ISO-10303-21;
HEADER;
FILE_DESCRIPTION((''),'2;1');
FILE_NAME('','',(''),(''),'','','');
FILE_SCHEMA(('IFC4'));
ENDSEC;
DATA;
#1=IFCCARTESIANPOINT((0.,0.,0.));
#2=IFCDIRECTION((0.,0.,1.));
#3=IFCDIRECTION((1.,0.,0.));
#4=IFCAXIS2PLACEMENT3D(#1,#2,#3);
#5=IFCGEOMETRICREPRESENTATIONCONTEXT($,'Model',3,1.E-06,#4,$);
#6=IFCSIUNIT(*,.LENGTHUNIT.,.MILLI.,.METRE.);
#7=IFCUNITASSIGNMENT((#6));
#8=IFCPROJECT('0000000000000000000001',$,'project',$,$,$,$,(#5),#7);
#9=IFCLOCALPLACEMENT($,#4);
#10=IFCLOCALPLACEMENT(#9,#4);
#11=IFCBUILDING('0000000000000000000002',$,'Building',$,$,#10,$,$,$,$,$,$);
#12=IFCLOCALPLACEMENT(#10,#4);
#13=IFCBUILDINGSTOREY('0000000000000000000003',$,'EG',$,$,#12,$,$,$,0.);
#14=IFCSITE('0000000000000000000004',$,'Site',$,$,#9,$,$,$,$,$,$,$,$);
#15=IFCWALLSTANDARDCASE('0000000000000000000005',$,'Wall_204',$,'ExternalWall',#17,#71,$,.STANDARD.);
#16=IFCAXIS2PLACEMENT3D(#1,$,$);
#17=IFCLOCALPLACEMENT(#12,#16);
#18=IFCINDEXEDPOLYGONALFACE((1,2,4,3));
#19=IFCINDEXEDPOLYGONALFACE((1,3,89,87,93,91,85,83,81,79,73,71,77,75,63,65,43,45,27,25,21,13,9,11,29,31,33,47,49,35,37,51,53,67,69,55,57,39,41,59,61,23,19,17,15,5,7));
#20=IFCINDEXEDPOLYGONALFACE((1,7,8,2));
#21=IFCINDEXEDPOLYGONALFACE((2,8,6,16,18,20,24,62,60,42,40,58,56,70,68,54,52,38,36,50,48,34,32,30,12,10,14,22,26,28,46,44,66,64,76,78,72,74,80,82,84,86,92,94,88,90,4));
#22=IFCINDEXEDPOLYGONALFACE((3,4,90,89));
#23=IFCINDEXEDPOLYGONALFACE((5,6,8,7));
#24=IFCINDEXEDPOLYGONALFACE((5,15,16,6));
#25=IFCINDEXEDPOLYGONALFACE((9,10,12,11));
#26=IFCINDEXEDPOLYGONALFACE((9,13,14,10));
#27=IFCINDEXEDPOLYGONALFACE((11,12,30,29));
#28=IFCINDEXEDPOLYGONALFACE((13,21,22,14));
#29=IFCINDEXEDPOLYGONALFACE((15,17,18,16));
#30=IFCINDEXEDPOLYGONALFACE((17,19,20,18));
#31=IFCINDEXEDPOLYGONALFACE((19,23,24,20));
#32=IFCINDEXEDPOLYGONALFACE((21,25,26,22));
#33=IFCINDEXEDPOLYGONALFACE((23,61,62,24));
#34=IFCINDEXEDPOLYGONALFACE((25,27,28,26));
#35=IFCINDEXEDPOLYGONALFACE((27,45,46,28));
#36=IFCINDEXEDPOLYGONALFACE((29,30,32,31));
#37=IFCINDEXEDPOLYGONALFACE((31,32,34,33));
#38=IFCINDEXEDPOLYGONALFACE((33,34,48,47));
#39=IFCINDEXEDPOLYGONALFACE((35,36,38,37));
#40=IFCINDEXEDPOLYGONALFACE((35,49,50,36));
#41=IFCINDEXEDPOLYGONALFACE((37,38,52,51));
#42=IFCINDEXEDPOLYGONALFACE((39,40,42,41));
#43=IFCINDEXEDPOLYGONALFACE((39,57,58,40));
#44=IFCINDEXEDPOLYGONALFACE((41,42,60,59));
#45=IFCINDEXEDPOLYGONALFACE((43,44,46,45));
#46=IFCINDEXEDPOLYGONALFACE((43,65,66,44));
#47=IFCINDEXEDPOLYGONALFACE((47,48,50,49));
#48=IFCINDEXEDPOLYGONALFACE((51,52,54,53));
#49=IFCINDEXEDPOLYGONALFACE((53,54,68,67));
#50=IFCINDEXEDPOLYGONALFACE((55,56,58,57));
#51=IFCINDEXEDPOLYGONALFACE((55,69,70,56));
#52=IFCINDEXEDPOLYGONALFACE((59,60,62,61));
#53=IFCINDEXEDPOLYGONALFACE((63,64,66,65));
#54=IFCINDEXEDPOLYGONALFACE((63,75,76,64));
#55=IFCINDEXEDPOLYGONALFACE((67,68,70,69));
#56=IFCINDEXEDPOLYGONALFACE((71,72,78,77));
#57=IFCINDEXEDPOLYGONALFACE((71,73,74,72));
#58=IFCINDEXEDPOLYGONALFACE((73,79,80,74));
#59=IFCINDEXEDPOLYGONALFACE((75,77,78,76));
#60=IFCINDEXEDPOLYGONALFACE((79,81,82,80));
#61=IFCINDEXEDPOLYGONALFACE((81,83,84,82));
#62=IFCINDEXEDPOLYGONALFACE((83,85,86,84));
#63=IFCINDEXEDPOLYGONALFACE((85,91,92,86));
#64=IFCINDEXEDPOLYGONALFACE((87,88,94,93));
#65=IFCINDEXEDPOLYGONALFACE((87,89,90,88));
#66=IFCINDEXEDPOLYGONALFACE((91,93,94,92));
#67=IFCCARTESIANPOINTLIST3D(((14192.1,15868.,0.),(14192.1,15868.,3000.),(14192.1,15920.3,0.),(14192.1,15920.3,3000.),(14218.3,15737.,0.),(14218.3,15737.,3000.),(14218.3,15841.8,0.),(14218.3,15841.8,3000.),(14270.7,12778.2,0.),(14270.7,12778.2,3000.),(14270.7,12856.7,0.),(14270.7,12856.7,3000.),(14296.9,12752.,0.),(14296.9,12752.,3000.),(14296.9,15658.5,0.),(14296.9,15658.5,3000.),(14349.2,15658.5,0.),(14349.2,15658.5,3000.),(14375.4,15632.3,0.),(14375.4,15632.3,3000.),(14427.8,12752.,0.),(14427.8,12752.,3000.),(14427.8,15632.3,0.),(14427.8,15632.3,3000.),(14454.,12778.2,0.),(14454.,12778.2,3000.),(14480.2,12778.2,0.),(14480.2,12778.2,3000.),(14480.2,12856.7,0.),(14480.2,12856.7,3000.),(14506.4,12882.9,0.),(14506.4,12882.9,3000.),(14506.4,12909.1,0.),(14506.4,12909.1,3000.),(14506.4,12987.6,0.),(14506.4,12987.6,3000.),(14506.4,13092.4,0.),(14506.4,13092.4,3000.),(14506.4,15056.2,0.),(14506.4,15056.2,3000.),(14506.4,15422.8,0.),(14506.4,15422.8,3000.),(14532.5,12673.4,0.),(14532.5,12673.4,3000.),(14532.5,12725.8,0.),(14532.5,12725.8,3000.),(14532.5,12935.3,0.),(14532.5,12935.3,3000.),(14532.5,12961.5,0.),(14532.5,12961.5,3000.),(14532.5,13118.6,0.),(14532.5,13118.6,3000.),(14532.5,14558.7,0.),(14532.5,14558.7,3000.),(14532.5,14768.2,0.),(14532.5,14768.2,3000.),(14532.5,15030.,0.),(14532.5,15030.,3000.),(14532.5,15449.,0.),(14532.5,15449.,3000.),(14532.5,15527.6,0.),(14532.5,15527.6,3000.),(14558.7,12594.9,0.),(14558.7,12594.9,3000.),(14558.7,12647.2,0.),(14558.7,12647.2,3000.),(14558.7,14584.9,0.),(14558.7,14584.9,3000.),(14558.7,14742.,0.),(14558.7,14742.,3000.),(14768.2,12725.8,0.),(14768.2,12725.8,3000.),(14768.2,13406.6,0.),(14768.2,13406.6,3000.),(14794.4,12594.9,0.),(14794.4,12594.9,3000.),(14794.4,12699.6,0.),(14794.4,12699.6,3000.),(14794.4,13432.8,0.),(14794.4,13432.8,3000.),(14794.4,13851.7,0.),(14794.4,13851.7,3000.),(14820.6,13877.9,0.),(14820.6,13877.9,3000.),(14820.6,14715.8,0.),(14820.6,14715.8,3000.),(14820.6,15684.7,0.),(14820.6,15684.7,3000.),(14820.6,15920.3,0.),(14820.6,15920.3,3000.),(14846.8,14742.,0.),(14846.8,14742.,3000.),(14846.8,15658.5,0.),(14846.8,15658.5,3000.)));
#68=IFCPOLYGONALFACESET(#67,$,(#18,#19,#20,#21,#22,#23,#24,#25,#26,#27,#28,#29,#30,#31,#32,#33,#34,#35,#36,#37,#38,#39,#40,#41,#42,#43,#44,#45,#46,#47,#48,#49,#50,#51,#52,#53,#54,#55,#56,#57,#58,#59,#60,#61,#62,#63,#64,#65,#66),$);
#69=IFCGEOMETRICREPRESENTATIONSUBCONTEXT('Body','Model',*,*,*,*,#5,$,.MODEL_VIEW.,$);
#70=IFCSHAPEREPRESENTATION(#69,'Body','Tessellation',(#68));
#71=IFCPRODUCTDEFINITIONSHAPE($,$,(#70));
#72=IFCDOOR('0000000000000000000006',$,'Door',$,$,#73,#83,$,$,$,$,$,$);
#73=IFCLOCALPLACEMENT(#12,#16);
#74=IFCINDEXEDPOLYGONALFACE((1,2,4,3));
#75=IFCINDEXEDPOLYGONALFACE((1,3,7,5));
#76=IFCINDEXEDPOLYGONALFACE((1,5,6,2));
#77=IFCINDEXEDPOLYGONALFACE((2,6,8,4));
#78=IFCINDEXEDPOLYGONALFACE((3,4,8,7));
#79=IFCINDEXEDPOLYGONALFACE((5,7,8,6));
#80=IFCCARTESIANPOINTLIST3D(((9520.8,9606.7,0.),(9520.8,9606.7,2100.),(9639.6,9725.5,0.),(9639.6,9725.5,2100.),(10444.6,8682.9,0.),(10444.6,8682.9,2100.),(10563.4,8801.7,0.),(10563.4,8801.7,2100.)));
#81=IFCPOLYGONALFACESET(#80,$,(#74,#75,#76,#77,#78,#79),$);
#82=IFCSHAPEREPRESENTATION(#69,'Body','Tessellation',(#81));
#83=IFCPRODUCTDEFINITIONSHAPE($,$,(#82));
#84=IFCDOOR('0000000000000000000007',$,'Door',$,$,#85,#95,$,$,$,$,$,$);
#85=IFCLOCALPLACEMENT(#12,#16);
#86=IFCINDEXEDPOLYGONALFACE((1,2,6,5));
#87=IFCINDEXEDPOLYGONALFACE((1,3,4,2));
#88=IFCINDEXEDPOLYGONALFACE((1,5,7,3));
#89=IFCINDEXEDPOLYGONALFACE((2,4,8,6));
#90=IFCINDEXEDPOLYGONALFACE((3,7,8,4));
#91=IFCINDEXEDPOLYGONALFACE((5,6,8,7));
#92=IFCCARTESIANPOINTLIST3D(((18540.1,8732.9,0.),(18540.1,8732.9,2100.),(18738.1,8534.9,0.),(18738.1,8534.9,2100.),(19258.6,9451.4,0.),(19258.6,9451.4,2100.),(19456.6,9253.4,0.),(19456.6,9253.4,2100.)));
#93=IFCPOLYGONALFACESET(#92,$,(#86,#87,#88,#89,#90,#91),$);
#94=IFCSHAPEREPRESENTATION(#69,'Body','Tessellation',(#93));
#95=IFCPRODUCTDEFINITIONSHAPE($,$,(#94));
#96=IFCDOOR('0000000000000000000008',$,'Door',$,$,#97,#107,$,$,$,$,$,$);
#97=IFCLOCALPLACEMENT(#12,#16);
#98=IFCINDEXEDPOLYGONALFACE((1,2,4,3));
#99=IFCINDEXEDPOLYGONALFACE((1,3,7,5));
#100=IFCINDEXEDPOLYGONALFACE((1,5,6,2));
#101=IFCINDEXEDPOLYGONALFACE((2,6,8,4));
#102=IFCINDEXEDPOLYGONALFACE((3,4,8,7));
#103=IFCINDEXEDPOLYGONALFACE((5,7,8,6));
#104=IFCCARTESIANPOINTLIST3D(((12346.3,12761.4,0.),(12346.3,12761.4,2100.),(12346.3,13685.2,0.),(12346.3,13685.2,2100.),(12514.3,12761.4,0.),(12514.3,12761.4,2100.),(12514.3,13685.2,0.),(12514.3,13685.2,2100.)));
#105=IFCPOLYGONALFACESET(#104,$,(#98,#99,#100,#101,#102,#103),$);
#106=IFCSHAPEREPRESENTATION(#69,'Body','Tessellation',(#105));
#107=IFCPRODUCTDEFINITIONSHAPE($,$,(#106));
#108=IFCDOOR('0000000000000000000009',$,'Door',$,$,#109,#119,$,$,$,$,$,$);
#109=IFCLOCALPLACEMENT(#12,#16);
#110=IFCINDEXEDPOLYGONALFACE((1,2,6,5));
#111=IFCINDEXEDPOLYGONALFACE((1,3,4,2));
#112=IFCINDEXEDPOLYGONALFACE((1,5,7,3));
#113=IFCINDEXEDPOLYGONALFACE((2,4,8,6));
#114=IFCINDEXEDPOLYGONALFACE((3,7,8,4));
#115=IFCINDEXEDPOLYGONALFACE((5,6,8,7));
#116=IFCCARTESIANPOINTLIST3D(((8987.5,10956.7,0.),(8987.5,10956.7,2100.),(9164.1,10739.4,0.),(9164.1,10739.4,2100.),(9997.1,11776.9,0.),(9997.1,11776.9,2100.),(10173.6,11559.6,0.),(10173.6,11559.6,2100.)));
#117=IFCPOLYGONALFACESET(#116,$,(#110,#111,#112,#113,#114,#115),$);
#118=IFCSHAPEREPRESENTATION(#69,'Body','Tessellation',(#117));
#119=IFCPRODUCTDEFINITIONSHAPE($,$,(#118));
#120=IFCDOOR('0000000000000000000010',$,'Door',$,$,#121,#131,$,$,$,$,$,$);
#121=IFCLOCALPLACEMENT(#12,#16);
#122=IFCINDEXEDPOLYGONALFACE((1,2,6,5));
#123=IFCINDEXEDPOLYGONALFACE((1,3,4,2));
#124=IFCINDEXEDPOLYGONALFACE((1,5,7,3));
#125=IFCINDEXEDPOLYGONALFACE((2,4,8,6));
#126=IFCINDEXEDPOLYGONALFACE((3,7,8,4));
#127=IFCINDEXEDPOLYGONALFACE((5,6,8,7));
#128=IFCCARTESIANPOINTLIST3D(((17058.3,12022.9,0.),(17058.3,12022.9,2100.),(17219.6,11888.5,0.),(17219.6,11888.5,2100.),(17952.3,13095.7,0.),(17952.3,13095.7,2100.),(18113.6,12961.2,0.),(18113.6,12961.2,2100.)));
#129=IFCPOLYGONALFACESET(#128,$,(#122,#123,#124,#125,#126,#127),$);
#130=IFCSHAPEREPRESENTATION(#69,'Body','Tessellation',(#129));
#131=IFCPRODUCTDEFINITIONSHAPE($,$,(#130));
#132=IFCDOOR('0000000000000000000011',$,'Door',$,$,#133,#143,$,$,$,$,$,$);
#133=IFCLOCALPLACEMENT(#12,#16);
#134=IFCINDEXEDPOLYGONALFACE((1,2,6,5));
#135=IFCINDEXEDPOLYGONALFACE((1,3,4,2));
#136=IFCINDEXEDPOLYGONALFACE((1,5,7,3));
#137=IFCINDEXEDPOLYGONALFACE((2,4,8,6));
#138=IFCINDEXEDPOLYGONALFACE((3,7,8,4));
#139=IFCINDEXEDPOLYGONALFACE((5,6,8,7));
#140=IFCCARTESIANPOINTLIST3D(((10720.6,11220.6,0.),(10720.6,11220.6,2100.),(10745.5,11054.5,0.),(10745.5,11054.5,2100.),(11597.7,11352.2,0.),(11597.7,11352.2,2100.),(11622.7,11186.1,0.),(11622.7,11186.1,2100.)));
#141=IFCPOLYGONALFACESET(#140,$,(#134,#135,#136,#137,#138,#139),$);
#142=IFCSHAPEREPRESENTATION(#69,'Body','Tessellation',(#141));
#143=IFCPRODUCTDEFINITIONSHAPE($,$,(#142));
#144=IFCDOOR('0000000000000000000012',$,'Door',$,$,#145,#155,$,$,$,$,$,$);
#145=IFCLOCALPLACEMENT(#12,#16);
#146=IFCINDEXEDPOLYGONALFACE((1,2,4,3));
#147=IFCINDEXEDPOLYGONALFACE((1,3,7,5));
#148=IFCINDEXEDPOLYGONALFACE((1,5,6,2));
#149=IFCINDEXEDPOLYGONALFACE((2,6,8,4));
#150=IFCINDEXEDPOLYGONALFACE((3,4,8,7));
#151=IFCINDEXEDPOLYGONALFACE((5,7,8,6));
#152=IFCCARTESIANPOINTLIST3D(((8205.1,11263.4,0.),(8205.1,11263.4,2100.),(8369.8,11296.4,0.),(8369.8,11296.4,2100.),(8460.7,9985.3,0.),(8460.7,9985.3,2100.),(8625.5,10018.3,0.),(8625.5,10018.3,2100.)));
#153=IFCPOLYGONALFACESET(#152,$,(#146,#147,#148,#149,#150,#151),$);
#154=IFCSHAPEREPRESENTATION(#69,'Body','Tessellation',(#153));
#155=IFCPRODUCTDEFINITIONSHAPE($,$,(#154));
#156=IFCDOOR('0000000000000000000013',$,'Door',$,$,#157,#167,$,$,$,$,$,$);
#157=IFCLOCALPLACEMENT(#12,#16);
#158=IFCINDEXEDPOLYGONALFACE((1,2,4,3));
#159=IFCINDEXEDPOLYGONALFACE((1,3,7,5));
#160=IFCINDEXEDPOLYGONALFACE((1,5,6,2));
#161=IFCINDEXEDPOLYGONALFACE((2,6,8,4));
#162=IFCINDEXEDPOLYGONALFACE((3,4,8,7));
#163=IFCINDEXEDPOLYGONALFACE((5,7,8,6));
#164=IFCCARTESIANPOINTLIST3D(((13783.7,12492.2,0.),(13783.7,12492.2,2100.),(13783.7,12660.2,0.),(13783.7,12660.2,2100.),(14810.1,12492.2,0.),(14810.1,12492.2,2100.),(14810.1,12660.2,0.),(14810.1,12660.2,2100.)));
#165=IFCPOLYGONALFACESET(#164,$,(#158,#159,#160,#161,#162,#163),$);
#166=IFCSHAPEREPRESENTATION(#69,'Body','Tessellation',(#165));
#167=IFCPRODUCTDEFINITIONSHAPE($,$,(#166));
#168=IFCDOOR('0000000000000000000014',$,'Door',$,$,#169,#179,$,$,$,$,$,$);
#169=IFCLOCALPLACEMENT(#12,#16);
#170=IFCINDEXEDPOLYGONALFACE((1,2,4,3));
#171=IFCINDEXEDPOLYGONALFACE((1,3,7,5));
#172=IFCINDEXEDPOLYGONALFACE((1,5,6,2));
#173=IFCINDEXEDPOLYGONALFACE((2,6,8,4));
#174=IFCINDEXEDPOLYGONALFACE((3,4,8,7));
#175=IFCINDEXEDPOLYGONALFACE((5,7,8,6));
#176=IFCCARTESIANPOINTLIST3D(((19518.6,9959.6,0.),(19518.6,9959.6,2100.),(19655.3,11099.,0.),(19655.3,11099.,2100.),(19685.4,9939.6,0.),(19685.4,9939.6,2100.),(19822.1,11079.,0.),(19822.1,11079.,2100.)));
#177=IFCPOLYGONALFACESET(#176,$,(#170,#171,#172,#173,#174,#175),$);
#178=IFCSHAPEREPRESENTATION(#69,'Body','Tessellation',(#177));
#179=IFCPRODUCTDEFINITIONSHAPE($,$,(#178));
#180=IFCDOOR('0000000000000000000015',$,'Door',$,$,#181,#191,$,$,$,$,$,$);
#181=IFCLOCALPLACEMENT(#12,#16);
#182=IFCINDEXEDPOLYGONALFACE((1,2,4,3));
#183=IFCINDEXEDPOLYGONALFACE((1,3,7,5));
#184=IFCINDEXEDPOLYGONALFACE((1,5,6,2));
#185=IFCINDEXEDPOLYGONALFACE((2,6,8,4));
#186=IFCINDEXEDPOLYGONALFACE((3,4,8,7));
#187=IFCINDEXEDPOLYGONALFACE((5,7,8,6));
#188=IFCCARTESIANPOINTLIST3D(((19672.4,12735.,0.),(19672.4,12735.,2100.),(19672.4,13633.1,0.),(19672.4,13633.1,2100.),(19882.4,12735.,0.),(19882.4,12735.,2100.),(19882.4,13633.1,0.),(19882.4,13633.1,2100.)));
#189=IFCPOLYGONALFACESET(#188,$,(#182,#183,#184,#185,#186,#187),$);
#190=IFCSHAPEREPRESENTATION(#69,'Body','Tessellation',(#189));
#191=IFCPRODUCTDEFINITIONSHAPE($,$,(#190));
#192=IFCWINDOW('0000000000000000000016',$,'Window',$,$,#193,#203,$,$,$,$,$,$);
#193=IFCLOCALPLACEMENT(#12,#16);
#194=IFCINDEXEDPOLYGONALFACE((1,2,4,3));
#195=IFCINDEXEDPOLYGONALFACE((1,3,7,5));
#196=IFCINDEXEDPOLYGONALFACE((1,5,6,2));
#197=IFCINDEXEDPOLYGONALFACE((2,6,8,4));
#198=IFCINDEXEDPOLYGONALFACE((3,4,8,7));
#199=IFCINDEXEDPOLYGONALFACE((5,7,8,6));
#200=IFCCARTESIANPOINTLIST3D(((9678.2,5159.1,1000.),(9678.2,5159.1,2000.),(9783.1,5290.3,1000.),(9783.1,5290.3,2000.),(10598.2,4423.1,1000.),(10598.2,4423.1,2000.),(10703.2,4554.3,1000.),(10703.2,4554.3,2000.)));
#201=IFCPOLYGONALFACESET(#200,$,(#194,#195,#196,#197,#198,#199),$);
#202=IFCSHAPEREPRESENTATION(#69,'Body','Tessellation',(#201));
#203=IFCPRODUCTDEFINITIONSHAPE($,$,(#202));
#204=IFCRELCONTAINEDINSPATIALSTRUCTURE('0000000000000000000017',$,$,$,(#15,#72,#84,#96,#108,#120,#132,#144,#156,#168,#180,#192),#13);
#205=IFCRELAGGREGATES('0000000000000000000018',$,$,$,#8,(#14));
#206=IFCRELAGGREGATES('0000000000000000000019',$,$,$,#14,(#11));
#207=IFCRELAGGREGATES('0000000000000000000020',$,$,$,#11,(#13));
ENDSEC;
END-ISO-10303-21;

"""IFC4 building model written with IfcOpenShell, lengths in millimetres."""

from ifc_helpers import new_model, si_unit, frame, origin_with_axes, place, context, subcontext, project, spatial, polyline, rectangle, outline, extrude, element, save


model = new_model("IFC4")

# Units and contexts
model_context = context("Model", 3, precision=1e-06, world=origin_with_axes())
body_context = subcontext(model_context, "Body", "Model", "MODEL_VIEW")
ifc_project = project(units=[si_unit("LENGTHUNIT", "METRE", prefix="MILLI")], contexts=[model_context])

# Site, building, storey
site_placement = place(None, origin_with_axes())
site = spatial("IfcSite", under=ifc_project, at=site_placement, Name="Site")
building_placement = place(site_placement, origin_with_axes())
building = spatial("IfcBuilding", under=site, at=building_placement, Name="Building")
storey_placement = place(building_placement, origin_with_axes())
storey = spatial("IfcBuildingStorey", under=building, at=storey_placement, Name="EG", Elevation=0.0)

# Wall
wall_placement = place(storey_placement, origin_with_axes())
element("IfcWallStandardCase", 1, at=wall_placement, inside=storey, Name="Wall_204", ObjectType="ExternalWall", PredefinedType="STANDARD", context=body_context, shape_type="SweptSolid", body=[
    extrude(outline(polyline([(14558.7, 12594.9, 0.0), (14558.7, 12647.2, 0.0), (14532.5, 12673.4, 0.0), (14532.5, 12725.8, 0.0), (14480.2, 12778.2, 0.0), (14454.0, 12778.2, 0.0), (14427.8, 12752.0, 0.0), (14296.9, 12752.0, 0.0), (14270.7, 12778.2, 0.0), (14270.7, 12856.7, 0.0), (14480.2, 12856.7, 0.0), (14506.4, 12882.9, 0.0), (14506.4, 12909.1, 0.0), (14532.5, 12935.3, 0.0), (14532.5, 12961.5, 0.0), (14506.4, 12987.6, 0.0), (14506.4, 13092.4, 0.0), (14532.5, 13118.6, 0.0), (14532.5, 14558.7, 0.0), (14558.7, 14584.9, 0.0), (14558.7, 14742.0, 0.0), (14532.5, 14768.2, 0.0), (14532.5, 15030.0, 0.0), (14506.4, 15056.2, 0.0), (14506.4, 15422.8, 0.0), (14532.5, 15449.0, 0.0), (14532.5, 15527.6, 0.0), (14427.8, 15632.3, 0.0), (14375.4, 15632.3, 0.0), (14349.2, 15658.5, 0.0), (14296.9, 15658.5, 0.0), (14218.3, 15737.0, 0.0), (14218.3, 15841.8, 0.0), (14192.1, 15868.0, 0.0), (14192.1, 15920.3, 0.0), (14820.6, 15920.3, 0.0), (14820.6, 15684.7, 0.0), (14846.8, 15658.5, 0.0), (14846.8, 14742.0, 0.0), (14820.6, 14715.8, 0.0), (14820.6, 13877.9, 0.0), (14794.4, 13851.7, 0.0), (14794.4, 13432.8, 0.0), (14768.2, 13406.6, 0.0), (14768.2, 12725.8, 0.0), (14794.4, 12699.6, 0.0), (14794.4, 12594.9, 0.0), (14558.7, 12594.9, 0.0)])), origin_with_axes(), (0.0, 0.0, 1.0), 3000.0),
])

# Doors
door_1_placement = place(storey_placement, origin_with_axes())
element("IfcDoor", 2, at=door_1_placement, inside=storey, Name="Door", context=body_context, shape_type="SweptSolid", body=[
    extrude(rectangle(XDim=1306.4, YDim=168.0), frame((10042.1, 9204.2, 0.0), z_axis=(0.0, 0.0, 1.0), x_axis=(0.707107, -0.707107, 0.0)), (0.0, 0.0, 1.0), 2100.0),
])
door_2_placement = place(storey_placement, origin_with_axes())
element("IfcDoor", 3, at=door_2_placement, inside=storey, Name="Door", context=body_context, shape_type="SweptSolid", body=[
    extrude(rectangle(XDim=1016.1, YDim=280.0), frame((18998.3, 8993.2, 0.0), z_axis=(0.0, 0.0, 1.0), x_axis=(-0.707107, -0.707107, 0.0)), (0.0, 0.0, 1.0), 2100.0),
])
door_3_placement = place(storey_placement, origin_with_axes())
element("IfcDoor", 4, at=door_3_placement, inside=storey, Name="Door", context=body_context, shape_type="SweptSolid", body=[
    extrude(rectangle(XDim=923.8, YDim=168.0), frame((12430.3, 13223.3, 0.0), z_axis=(0.0, 0.0, 1.0), x_axis=(0.0, -1.0, 0.0)), (0.0, 0.0, 1.0), 2100.0),
])
door_4_placement = place(storey_placement, origin_with_axes())
element("IfcDoor", 5, at=door_4_placement, inside=storey, Name="Door", context=body_context, shape_type="SweptSolid", body=[
    extrude(rectangle(XDim=1300.8, YDim=280.0), frame((9580.6, 11258.1, 0.0), z_axis=(0.0, 0.0, 1.0), x_axis=(-0.776114, -0.630593, 0.0)), (0.0, 0.0, 1.0), 2100.0),
])
door_5_placement = place(storey_placement, origin_with_axes())
element("IfcDoor", 6, at=door_5_placement, inside=storey, Name="Door", context=body_context, shape_type="SweptSolid", body=[
    extrude(rectangle(XDim=1396.4, YDim=210.0), frame((17585.9, 12492.1, 0.0), z_axis=(0.0, 0.0, 1.0), x_axis=(-0.640184, -0.768221, 0.0)), (0.0, 0.0, 1.0), 2100.0),
])
door_6_placement = place(storey_placement, origin_with_axes())
element("IfcDoor", 7, at=door_6_placement, inside=storey, Name="Door", context=body_context, shape_type="SweptSolid", body=[
    extrude(rectangle(XDim=886.9, YDim=168.0), frame((11171.6, 11203.3, 0.0), z_axis=(0.0, 0.0, 1.0), x_axis=(-0.988936, -0.14834, 0.0)), (0.0, 0.0, 1.0), 2100.0),
])
door_7_placement = place(storey_placement, origin_with_axes())
element("IfcDoor", 8, at=door_7_placement, inside=storey, Name="Door", context=body_context, shape_type="SweptSolid", body=[
    extrude(rectangle(XDim=1303.4, YDim=168.0), frame((8415.3, 10640.9, 0.0), z_axis=(0.0, 0.0, 1.0), x_axis=(-0.196116, 0.980581, 0.0)), (0.0, 0.0, 1.0), 2100.0),
])
door_8_placement = place(storey_placement, origin_with_axes())
element("IfcDoor", 9, at=door_8_placement, inside=storey, Name="Door", context=body_context, shape_type="SweptSolid", body=[
    extrude(rectangle(XDim=1026.4, YDim=168.0), frame((14296.9, 12576.2, 0.0), z_axis=(0.0, 0.0, 1.0), x_axis=(1.0, 0.0, 0.0)), (0.0, 0.0, 1.0), 2100.0),
])
door_9_placement = place(storey_placement, origin_with_axes())
element("IfcDoor", 10, at=door_9_placement, inside=storey, Name="Door", context=body_context, shape_type="SweptSolid", body=[
    extrude(rectangle(XDim=1147.5, YDim=168.0), frame((19670.4, 10519.3, 0.0), z_axis=(0.0, 0.0, 1.0), x_axis=(-0.119145, -0.992877, 0.0)), (0.0, 0.0, 1.0), 2100.0),
])
door_10_placement = place(storey_placement, origin_with_axes())
element("IfcDoor", 11, at=door_10_placement, inside=storey, Name="Door", context=body_context, shape_type="SweptSolid", body=[
    extrude(rectangle(XDim=898.1, YDim=210.0), frame((19777.4, 13184.0, 0.0), z_axis=(0.0, 0.0, 1.0), x_axis=(0.0, -1.0, 0.0)), (0.0, 0.0, 1.0), 2100.0),
])

# Window
window_1_placement = place(storey_placement, origin_with_axes())
element("IfcWindow", 12, at=window_1_placement, inside=storey, Name="Window", context=body_context, shape_type="SweptSolid", body=[
    extrude(rectangle(XDim=1178.2, YDim=168.0), frame((10190.7, 4856.7, 1000.0), z_axis=(0.0, 0.0, 1.0), x_axis=(0.780869, -0.624695, 0.0)), (0.0, 0.0, 1.0), 1000.0),
])

save(model, "model.ifc")
